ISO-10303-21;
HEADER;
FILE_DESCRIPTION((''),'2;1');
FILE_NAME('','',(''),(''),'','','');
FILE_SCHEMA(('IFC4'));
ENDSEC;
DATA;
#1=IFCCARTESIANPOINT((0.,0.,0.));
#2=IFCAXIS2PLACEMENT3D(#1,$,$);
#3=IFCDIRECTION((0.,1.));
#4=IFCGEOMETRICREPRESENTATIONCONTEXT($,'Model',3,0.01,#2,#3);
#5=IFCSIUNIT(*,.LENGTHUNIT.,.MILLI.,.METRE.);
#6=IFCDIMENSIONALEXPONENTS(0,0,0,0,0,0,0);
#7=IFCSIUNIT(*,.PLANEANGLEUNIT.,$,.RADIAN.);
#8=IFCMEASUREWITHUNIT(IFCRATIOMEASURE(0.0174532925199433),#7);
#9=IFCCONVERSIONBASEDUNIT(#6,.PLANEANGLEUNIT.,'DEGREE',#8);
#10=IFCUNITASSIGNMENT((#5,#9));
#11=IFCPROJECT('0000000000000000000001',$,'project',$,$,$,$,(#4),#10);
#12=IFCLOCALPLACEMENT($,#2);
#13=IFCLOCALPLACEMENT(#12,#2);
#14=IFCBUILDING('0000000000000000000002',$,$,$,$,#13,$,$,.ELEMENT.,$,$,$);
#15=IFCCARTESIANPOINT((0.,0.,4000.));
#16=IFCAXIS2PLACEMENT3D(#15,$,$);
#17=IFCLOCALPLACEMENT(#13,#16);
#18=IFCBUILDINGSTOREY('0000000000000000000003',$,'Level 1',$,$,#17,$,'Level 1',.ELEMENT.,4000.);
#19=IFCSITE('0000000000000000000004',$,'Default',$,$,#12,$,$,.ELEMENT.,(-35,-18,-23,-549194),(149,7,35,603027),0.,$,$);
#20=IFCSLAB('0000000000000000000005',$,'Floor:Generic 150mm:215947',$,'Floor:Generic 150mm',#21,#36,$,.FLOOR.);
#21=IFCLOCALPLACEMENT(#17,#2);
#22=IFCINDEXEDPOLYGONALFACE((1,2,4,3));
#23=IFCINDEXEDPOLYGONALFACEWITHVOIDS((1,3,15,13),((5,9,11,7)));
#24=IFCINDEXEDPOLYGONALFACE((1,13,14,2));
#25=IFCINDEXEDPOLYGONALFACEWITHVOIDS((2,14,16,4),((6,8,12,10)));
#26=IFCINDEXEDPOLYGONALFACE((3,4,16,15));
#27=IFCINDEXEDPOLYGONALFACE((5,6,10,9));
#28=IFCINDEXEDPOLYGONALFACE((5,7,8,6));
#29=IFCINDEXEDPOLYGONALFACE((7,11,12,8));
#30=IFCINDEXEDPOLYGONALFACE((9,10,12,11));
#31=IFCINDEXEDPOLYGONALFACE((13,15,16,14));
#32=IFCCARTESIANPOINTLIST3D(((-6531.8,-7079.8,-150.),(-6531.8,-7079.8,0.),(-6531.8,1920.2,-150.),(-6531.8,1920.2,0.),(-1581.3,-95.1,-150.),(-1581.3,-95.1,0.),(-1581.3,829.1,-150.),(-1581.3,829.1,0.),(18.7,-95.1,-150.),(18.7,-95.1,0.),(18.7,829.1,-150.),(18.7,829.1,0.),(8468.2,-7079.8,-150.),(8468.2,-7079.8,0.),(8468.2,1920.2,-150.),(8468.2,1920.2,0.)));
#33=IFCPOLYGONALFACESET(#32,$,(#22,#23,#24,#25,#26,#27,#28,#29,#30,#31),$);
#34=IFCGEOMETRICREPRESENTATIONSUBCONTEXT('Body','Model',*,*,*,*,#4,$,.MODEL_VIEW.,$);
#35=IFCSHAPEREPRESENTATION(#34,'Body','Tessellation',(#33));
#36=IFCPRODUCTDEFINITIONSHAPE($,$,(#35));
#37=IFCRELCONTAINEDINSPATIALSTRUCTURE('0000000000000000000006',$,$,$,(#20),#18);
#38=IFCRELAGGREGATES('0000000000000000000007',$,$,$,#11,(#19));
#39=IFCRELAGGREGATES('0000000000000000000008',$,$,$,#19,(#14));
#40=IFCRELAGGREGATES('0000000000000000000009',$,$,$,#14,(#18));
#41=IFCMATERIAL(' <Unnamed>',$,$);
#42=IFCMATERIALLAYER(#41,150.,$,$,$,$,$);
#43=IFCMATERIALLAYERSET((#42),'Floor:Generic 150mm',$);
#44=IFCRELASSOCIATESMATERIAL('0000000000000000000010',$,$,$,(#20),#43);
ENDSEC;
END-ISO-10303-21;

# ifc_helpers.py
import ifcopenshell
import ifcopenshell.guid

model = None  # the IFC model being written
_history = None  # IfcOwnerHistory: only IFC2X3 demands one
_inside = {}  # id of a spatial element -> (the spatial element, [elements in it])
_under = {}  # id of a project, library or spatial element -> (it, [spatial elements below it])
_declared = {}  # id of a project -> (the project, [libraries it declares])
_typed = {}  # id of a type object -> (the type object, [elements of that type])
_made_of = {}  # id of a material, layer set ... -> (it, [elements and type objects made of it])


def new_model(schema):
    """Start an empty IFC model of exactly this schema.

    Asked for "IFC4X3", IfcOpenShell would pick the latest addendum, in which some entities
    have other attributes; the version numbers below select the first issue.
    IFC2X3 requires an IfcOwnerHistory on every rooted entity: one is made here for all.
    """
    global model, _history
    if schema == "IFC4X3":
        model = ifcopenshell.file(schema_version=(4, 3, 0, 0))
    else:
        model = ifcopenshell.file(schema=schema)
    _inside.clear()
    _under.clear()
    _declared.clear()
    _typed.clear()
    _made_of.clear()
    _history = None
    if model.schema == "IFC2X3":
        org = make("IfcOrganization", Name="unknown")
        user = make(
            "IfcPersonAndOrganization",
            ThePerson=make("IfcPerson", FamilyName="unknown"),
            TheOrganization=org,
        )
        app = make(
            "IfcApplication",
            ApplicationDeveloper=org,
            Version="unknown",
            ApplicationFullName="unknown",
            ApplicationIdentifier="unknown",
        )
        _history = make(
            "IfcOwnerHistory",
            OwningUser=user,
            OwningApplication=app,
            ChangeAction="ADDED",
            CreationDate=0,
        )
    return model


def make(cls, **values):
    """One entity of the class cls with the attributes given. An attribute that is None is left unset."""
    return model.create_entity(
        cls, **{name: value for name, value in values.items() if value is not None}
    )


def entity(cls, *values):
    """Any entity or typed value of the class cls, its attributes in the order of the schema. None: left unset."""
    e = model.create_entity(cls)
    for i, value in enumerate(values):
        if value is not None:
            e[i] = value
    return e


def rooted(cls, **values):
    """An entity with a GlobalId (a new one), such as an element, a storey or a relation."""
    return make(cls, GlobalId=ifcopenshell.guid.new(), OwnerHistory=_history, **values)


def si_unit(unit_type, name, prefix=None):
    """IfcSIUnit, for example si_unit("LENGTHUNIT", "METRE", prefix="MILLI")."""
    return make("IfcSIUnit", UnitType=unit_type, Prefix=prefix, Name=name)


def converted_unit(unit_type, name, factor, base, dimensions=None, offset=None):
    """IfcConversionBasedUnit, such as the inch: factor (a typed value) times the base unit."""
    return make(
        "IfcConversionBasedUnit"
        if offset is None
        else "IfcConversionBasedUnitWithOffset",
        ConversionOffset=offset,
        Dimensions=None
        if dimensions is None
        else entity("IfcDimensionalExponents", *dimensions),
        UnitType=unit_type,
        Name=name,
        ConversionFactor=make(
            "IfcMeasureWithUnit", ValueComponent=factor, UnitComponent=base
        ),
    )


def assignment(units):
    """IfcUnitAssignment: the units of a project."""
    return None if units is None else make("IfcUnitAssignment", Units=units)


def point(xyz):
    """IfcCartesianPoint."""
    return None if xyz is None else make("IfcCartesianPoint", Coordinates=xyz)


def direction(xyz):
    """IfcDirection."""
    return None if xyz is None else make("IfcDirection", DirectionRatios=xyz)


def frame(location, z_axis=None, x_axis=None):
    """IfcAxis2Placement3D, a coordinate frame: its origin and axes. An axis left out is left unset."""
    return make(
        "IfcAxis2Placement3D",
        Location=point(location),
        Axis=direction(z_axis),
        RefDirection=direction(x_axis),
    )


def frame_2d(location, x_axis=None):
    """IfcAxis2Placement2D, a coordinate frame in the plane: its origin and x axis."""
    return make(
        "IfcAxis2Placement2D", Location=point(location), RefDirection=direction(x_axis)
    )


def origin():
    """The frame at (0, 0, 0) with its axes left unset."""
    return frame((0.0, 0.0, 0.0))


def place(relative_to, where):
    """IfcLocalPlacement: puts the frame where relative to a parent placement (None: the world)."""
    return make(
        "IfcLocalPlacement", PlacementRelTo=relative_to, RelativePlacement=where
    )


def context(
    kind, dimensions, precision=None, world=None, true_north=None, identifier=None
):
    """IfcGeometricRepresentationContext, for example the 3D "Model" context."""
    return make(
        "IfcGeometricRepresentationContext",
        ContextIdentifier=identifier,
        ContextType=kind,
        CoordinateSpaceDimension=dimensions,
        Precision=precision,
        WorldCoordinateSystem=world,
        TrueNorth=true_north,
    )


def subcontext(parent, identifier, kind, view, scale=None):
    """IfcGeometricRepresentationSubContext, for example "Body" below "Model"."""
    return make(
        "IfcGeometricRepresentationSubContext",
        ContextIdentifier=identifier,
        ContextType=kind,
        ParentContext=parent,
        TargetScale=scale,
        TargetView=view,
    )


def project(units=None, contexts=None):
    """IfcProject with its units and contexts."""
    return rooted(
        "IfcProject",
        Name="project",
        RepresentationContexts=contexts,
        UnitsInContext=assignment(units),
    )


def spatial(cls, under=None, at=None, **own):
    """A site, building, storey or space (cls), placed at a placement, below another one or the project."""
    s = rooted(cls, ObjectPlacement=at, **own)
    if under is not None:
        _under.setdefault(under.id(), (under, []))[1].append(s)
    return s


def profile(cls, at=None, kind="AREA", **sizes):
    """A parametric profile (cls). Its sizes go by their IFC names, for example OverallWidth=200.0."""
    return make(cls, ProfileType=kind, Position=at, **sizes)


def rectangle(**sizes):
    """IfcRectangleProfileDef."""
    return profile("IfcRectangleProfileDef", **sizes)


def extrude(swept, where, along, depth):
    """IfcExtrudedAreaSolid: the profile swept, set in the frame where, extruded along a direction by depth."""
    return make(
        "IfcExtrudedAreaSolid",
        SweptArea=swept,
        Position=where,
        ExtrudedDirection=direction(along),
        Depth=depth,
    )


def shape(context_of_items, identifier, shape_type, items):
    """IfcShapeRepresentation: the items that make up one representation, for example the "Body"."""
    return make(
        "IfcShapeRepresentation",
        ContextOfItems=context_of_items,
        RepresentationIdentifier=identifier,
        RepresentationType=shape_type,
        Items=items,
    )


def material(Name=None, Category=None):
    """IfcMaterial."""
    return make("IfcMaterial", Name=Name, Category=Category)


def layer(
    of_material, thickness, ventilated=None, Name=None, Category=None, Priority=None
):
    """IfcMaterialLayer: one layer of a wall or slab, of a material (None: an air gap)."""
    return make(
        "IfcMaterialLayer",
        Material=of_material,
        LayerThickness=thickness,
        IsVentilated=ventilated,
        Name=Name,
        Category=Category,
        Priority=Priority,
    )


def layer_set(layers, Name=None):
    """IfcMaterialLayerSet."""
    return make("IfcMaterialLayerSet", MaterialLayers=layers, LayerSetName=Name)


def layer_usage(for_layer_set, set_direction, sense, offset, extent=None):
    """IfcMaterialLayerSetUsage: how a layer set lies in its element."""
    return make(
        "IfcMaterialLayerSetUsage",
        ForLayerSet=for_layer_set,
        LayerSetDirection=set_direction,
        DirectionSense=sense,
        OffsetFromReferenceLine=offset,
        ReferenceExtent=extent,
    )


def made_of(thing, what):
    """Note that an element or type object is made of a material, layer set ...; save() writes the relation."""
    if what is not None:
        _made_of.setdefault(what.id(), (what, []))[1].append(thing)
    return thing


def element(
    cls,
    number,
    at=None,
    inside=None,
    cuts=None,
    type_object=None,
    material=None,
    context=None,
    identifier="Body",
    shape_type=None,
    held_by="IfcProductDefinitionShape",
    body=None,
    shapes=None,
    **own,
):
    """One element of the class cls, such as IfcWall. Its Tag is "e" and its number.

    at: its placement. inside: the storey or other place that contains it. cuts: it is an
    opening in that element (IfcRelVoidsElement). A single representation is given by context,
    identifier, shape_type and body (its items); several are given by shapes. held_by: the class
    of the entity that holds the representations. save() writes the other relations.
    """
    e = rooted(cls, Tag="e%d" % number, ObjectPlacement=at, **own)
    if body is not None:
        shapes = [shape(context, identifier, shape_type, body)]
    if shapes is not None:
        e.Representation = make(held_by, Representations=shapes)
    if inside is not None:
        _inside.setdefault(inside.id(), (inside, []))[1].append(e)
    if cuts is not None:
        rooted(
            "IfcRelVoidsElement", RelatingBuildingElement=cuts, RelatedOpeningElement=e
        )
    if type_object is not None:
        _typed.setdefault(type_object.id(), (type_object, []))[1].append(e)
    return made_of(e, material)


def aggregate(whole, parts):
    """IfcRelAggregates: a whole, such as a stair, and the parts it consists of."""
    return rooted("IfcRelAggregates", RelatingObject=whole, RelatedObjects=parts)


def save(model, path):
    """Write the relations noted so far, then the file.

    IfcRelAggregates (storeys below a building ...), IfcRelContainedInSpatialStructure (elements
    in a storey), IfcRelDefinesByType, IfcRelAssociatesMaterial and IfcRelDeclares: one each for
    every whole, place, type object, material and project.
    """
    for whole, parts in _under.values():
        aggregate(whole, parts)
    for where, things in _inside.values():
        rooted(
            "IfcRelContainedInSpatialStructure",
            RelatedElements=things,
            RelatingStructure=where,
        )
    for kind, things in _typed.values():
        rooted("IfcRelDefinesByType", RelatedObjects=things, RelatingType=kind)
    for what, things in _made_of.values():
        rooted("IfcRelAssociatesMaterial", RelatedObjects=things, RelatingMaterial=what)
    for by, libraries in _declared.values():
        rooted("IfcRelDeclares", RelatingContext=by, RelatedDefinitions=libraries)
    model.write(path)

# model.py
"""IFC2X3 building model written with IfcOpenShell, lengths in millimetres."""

from ifc_helpers import new_model, entity, si_unit, converted_unit, direction, frame, frame_2d, origin, place, context, subcontext, project, spatial, rectangle, extrude, material, layer, layer_set, layer_usage, element, save


model = new_model("IFC2X3")

# Units and contexts
model_context = context("Model", 3, precision=0.01, world=origin(), true_north=direction((0.0, 1.0)))
body_context = subcontext(model_context, "Body", "Model", "MODEL_VIEW")
ifc_project = project(units=[si_unit("LENGTHUNIT", "METRE", prefix="MILLI"), converted_unit("PLANEANGLEUNIT", "DEGREE", entity("IfcRatioMeasure", 0.0174532925199433), si_unit("PLANEANGLEUNIT", "RADIAN"), dimensions=[0, 0, 0, 0, 0, 0, 0])], contexts=[model_context])

# Site, building, storey
site_placement = place(None, origin())
site = spatial("IfcSite", under=ifc_project, at=site_placement, Name="Default", CompositionType="ELEMENT", RefLatitude=(-35, -18, -23, -549194), RefLongitude=(149, 7, 35, 603027), RefElevation=0.0)
building_placement = place(site_placement, origin())
building = spatial("IfcBuilding", under=site, at=building_placement, CompositionType="ELEMENT")
storey_placement = place(building_placement, frame((0.0, 0.0, 4000.0)))
storey = spatial("IfcBuildingStorey", under=building, at=storey_placement, Name="Level 1", LongName="Level 1", CompositionType="ELEMENT", Elevation=4000.0)

# Slab, opening
ifc_material_1 = material(Name=" <Unnamed>")
ifc_layer_1 = layer(ifc_material_1, 150.0)
ifc_layer_set_1 = layer_set([ifc_layer_1], Name="Floor:Generic 150mm")
ifc_layer_usage_1 = layer_usage(ifc_layer_set_1, "AXIS3", "POSITIVE", 0.0)
slab_placement = place(storey_placement, frame((-6531.8, -7079.8, -150.0)))
slab = element("IfcSlab", 1, at=slab_placement, inside=storey, material=ifc_layer_usage_1, Name="Floor:Generic 150mm:215947", ObjectType="Floor:Generic 150mm", PredefinedType="FLOOR", context=body_context, shape_type="SweptSolid", body=[
    extrude(rectangle(XDim=9000.0, YDim=15000.0, at=frame_2d((0.0, 0.0), x_axis=(0.0, -1.0))), frame((7500.0, 4500.0, 150.0), z_axis=(0.0, 0.0, -1.0), x_axis=(-1.0, 0.0, 0.0)), (0.0, 0.0, 1.0), 150.0),
])
opening_placement = place(storey_placement, frame((-6531.8, -7079.8, -150.0)))
element("IfcOpeningElement", 2, at=opening_placement, cuts=slab, ObjectType="Opening", context=body_context, shape_type="SweptSolid", body=[
    extrude(rectangle(XDim=1600.0, YDim=924.2, at=frame_2d((1749.5, 2946.8), x_axis=(1.0, 0.0))), frame((7500.0, 4500.0, 150.0), z_axis=(0.0, 0.0, -1.0), x_axis=(-1.0, 0.0, 0.0)), (0.0, 0.0, 1.0), 150.0),
])

save(model, "model.ifc")
